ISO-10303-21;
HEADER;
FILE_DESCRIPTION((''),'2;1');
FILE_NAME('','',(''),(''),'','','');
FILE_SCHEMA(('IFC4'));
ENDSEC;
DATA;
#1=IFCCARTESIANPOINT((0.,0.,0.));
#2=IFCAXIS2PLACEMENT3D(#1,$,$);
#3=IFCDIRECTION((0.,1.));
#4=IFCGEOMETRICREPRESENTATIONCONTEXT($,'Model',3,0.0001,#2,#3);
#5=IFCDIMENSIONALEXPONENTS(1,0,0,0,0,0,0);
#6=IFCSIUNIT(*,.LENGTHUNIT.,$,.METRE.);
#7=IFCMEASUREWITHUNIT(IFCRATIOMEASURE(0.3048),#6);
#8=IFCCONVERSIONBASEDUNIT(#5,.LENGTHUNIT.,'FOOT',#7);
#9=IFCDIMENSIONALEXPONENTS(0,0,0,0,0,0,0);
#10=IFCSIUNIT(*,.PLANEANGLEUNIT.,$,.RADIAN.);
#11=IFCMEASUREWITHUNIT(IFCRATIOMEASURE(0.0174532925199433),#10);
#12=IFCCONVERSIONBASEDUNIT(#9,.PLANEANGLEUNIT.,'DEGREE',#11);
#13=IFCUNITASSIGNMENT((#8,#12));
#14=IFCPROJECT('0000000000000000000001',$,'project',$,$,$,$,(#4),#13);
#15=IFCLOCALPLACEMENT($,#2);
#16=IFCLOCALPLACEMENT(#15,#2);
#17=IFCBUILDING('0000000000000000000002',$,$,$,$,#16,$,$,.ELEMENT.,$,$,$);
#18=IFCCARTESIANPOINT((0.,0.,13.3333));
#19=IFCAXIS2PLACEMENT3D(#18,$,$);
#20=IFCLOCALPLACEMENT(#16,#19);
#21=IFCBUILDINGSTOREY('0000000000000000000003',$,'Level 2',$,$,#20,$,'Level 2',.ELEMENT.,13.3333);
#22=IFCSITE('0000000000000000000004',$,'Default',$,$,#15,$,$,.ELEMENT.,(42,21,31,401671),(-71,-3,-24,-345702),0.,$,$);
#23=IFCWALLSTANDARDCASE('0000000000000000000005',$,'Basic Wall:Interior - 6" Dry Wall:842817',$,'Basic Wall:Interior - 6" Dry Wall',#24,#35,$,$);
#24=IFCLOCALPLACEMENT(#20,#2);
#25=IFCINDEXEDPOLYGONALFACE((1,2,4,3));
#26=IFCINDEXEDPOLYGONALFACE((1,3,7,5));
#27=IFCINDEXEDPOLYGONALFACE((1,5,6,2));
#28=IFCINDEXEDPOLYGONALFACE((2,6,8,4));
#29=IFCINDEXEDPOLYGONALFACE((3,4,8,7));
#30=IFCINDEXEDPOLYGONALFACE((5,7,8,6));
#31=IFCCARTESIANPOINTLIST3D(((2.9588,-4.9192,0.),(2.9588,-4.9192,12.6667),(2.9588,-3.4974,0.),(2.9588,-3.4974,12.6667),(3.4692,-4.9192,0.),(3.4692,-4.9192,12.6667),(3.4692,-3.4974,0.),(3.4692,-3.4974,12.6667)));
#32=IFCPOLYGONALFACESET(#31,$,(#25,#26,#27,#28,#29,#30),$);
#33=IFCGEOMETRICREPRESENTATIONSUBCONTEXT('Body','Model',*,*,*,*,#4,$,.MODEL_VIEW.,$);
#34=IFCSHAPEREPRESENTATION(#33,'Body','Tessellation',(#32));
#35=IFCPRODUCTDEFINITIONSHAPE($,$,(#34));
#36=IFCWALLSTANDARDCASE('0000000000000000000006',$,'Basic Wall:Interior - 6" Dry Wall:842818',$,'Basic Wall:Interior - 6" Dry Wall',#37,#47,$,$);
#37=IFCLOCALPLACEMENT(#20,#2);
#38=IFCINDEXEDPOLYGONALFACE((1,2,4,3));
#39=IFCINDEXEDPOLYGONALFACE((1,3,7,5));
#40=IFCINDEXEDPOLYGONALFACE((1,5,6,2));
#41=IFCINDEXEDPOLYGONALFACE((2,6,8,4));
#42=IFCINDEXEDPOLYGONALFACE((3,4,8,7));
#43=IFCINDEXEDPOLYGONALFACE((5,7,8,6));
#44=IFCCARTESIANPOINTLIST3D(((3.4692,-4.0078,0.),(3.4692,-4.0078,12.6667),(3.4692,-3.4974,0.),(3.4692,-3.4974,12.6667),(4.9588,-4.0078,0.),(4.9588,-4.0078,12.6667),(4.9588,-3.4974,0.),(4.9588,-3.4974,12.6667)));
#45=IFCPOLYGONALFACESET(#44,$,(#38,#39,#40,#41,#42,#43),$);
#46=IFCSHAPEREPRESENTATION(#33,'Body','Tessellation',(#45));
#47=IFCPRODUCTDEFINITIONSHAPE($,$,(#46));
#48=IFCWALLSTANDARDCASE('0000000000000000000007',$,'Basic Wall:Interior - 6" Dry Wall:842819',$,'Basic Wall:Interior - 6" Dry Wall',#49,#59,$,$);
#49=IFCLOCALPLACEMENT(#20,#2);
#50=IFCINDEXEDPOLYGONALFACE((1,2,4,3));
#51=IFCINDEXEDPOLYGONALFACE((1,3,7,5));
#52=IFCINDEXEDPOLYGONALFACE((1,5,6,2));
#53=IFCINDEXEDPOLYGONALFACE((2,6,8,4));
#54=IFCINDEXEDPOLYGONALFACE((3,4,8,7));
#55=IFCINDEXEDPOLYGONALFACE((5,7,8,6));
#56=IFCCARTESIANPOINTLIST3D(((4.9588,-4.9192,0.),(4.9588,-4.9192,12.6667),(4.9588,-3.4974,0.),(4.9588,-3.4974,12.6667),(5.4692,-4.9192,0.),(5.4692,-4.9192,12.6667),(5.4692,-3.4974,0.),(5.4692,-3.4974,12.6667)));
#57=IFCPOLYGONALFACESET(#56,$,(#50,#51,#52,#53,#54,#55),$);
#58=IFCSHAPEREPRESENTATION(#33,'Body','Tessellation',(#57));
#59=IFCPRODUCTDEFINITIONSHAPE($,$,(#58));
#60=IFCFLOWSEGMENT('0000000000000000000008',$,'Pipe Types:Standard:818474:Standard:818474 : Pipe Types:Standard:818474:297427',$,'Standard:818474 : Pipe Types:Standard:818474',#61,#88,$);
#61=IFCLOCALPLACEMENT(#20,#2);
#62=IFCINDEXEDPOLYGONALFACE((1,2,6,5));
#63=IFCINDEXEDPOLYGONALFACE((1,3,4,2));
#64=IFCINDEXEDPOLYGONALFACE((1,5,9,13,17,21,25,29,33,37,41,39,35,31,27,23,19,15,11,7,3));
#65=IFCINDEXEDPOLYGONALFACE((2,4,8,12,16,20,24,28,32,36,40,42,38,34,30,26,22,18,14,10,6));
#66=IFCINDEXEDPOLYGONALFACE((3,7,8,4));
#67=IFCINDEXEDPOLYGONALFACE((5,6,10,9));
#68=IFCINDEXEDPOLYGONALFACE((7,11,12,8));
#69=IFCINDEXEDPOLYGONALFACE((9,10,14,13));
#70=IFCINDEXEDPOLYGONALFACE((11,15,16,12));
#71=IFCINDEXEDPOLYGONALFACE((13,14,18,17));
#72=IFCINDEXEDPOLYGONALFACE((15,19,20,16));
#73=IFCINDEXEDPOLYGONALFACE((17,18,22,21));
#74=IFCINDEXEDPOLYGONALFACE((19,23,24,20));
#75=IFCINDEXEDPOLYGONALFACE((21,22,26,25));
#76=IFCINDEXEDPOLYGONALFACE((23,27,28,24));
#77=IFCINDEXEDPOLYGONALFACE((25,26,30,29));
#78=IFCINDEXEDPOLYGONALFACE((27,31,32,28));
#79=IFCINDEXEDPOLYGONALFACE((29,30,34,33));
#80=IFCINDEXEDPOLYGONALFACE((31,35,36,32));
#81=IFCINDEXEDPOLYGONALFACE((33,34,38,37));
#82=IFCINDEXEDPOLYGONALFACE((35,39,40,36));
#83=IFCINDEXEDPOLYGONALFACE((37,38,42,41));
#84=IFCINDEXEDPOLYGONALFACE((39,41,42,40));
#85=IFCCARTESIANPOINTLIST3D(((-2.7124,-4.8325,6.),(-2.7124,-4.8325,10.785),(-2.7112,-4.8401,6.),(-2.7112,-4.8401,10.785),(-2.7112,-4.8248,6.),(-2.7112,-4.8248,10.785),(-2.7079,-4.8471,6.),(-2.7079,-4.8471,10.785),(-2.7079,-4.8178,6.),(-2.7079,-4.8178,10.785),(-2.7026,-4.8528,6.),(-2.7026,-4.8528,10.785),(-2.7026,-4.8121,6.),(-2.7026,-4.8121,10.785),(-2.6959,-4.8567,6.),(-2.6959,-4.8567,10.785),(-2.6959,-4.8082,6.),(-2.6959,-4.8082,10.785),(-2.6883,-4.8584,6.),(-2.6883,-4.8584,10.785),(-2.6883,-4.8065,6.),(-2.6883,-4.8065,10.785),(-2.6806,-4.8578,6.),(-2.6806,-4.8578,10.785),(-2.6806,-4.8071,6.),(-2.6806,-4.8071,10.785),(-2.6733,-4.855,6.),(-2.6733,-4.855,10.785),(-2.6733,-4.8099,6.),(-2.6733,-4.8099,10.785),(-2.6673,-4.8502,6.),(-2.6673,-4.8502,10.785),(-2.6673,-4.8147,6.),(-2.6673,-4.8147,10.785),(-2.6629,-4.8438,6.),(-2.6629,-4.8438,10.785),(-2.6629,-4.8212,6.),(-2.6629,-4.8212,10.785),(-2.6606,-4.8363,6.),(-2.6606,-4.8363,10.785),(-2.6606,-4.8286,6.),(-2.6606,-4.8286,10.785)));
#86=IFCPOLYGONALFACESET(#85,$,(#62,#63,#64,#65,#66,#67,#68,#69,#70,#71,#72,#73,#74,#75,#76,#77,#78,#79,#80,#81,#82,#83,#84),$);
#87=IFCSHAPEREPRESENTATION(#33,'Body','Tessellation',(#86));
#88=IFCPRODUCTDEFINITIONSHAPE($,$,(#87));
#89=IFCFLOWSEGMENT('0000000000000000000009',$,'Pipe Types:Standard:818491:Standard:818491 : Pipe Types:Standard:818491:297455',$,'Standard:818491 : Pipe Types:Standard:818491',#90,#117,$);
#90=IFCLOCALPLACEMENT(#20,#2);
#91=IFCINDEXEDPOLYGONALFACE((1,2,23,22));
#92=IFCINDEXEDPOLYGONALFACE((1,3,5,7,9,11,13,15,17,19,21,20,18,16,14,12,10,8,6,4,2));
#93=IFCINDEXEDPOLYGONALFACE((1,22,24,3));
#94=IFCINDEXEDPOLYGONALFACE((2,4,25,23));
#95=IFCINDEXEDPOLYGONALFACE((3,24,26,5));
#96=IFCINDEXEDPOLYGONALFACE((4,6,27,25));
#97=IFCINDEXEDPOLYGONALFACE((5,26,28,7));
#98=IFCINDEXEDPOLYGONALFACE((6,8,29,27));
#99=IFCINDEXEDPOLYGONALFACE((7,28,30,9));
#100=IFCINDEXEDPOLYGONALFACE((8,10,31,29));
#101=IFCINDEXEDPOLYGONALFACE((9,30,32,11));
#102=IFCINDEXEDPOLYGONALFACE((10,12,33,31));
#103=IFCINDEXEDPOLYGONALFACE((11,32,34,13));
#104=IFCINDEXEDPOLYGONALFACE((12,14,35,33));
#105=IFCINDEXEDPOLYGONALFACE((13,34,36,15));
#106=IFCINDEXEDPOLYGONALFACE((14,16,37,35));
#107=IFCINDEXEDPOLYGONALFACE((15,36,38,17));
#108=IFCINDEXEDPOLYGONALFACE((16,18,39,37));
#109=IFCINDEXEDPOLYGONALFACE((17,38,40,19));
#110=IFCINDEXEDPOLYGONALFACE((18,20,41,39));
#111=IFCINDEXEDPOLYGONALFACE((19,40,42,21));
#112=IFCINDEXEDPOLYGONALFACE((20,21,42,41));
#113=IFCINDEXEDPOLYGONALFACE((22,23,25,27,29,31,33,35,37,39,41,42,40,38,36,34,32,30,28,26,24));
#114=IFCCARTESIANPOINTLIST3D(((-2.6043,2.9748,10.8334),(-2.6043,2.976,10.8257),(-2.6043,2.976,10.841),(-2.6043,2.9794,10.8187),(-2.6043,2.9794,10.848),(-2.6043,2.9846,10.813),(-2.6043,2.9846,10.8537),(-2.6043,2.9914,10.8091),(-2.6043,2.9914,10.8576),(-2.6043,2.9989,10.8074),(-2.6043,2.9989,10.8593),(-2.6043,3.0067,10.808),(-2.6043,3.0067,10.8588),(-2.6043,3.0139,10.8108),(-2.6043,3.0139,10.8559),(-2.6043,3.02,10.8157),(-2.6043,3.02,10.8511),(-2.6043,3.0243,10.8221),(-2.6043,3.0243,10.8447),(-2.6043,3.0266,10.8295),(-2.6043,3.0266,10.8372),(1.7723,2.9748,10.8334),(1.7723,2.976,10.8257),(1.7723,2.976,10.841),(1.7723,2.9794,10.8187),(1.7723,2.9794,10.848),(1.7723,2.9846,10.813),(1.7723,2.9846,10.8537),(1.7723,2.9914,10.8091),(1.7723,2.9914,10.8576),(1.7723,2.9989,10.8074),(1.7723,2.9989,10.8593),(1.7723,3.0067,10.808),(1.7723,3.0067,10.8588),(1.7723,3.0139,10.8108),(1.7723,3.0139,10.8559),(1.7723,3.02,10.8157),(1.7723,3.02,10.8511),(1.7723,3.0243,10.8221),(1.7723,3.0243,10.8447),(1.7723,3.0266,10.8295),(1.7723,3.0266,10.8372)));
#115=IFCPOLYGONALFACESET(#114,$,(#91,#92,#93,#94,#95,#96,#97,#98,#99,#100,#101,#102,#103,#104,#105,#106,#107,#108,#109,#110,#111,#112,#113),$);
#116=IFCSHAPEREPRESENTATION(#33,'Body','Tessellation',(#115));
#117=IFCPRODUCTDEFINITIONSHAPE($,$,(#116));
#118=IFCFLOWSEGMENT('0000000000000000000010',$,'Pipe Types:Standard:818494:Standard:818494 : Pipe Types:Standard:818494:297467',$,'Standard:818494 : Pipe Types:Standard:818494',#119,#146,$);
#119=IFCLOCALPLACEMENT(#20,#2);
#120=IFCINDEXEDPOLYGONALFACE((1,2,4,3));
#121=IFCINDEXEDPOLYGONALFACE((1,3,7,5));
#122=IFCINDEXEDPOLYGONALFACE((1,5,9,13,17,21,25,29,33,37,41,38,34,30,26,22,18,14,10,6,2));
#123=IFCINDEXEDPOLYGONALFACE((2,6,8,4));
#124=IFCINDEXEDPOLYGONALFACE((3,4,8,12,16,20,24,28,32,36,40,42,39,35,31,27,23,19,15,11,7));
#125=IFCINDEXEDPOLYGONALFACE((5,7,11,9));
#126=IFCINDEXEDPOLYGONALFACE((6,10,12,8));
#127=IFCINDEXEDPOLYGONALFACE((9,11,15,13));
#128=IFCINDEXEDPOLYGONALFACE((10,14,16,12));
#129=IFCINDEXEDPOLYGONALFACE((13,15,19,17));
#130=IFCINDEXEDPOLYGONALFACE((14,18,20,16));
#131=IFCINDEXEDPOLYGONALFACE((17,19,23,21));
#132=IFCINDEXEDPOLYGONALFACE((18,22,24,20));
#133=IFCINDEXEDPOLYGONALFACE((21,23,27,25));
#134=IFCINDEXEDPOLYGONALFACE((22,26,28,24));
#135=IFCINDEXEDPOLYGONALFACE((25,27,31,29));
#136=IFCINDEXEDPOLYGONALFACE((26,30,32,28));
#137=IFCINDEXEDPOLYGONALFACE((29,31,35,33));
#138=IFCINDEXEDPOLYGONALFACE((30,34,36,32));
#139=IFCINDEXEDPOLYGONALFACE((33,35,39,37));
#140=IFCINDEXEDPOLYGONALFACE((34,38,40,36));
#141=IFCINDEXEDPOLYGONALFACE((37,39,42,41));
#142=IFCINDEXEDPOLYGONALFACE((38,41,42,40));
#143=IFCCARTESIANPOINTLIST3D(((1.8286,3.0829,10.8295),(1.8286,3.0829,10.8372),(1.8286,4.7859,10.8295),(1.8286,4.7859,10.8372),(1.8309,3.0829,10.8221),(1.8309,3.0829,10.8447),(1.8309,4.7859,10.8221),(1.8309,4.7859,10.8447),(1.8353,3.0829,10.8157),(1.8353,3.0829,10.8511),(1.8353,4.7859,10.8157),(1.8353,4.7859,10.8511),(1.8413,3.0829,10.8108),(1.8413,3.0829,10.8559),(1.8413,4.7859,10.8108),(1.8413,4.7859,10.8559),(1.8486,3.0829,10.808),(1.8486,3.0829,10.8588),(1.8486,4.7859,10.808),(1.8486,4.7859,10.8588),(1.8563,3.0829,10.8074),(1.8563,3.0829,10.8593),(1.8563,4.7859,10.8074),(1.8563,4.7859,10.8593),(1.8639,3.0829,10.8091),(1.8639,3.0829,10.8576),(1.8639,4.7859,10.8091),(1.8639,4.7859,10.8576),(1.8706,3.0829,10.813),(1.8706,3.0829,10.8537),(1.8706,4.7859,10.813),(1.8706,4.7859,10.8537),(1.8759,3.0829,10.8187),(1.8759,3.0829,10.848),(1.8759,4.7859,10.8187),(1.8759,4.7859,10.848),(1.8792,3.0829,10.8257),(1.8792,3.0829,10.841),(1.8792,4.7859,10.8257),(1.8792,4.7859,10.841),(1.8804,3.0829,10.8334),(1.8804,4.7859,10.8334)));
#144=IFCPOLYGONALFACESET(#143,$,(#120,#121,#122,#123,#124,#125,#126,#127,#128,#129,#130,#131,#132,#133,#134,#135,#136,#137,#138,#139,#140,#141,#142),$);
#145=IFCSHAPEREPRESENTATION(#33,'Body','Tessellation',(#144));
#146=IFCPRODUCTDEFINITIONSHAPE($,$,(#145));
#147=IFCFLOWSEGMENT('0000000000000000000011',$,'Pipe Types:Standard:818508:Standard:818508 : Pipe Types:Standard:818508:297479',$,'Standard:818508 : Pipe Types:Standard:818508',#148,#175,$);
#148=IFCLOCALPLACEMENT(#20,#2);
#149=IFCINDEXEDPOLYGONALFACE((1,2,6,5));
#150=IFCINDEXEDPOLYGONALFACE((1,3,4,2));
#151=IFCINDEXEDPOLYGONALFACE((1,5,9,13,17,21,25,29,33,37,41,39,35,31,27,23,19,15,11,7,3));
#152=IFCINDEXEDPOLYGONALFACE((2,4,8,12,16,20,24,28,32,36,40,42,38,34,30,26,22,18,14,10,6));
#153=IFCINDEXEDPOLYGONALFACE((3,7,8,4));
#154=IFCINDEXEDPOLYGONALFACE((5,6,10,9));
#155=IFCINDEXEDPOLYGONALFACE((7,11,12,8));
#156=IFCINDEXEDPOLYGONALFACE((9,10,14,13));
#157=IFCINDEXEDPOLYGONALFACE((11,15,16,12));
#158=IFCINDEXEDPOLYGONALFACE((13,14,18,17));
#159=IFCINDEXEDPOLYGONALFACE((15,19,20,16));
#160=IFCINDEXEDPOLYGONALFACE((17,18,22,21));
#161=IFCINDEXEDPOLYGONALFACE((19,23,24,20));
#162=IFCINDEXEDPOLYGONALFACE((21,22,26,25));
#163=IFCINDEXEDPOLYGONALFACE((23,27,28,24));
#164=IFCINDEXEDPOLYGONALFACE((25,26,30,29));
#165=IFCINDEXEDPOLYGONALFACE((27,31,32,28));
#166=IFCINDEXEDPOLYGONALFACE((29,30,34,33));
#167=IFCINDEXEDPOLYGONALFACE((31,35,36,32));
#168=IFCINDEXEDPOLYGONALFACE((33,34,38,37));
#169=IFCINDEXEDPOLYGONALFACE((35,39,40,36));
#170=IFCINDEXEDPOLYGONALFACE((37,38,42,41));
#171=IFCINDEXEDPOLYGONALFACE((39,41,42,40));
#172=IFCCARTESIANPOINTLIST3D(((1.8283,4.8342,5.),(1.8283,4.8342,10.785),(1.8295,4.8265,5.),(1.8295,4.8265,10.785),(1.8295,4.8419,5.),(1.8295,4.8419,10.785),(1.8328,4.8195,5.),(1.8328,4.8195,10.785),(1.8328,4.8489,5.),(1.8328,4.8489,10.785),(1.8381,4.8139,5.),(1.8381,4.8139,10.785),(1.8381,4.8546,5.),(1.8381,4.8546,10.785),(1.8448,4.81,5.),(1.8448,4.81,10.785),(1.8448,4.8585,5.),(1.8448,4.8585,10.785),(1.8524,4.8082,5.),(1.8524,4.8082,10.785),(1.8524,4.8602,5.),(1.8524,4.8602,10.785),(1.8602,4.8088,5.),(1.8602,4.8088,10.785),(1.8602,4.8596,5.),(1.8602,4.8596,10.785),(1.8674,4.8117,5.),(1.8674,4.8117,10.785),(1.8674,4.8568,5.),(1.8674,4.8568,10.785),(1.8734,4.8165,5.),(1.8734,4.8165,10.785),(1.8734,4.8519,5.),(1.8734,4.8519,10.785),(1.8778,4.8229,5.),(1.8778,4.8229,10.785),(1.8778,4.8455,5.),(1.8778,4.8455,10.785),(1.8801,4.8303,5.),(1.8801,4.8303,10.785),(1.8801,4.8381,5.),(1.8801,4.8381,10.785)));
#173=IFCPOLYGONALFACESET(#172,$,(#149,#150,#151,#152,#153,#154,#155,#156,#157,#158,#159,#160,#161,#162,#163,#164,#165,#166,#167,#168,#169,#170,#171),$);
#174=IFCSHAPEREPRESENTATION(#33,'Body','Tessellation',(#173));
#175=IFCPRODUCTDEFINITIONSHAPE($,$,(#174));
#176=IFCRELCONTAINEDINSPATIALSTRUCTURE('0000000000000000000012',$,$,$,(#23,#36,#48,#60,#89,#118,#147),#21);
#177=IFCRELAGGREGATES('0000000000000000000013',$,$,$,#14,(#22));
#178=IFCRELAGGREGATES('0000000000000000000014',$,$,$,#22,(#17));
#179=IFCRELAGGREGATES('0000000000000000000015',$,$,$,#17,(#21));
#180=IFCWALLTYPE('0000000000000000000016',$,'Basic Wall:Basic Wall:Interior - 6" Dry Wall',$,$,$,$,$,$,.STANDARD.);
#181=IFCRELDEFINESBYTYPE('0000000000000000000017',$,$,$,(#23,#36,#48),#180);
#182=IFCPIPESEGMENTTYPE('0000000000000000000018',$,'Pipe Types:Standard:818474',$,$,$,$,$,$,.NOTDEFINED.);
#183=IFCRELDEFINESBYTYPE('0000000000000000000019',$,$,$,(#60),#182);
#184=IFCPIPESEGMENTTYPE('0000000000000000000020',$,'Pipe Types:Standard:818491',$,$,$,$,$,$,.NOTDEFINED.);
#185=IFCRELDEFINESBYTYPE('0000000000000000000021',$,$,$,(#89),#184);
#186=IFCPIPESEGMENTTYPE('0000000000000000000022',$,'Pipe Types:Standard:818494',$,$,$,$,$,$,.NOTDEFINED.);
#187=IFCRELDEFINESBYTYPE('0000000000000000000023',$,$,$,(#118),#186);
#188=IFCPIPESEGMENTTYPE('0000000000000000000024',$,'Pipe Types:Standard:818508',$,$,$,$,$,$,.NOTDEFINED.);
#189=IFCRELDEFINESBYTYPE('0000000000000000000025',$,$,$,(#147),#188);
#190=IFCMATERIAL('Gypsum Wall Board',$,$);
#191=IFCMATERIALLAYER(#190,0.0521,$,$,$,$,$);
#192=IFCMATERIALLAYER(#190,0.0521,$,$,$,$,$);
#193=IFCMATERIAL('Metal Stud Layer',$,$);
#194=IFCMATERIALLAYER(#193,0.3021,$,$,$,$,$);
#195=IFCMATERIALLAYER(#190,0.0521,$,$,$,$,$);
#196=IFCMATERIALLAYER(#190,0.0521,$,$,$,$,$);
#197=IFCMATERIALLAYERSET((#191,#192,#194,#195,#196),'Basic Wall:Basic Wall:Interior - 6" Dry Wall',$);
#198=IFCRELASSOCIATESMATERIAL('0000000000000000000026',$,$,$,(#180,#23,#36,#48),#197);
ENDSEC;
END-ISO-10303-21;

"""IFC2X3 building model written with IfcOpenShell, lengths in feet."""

from ifc_helpers import new_model, entity, si_unit, converted_unit, direction, frame, frame_2d, origin, origin_2d_with_axis, place, context, subcontext, project, spatial, rectangle, circle, extrude, source, transform, mapped, material, layer, layer_set, layer_usage, type_object, type_shapes, element, save


model = new_model("IFC2X3")

# Units and contexts
model_context = context("Model", 3, precision=0.0001, world=origin(), true_north=direction((0.0, 1.0)))
body_context = subcontext(model_context, "Body", "Model", "MODEL_VIEW")
ifc_project = project(units=[converted_unit("LENGTHUNIT", "FOOT", entity("IfcRatioMeasure", 0.3048), si_unit("LENGTHUNIT", "METRE"), dimensions=[1, 0, 0, 0, 0, 0, 0]), converted_unit("PLANEANGLEUNIT", "DEGREE", entity("IfcRatioMeasure", 0.0174532925199433), si_unit("PLANEANGLEUNIT", "RADIAN"), dimensions=[0, 0, 0, 0, 0, 0, 0])], contexts=[model_context])

# Site, building, storey
site_placement = place(None, origin())
site = spatial("IfcSite", under=ifc_project, at=site_placement, Name="Default", CompositionType="ELEMENT", RefLatitude=(42, 21, 31, 401671), RefLongitude=(-71, -3, -24, -345702), RefElevation=0.0)
building_placement = place(site_placement, origin())
building = spatial("IfcBuilding", under=site, at=building_placement, CompositionType="ELEMENT")
storey_placement = place(building_placement, frame((0.0, 0.0, 13.3333)))
storey = spatial("IfcBuildingStorey", under=building, at=storey_placement, Name="Level 2", LongName="Level 2", CompositionType="ELEMENT", Elevation=13.3333)

# Walls
ifc_material_1 = material(Name="Gypsum Wall Board")
ifc_layer_1 = layer(ifc_material_1, 0.0521)
ifc_layer_2 = layer(ifc_material_1, 0.0521)
ifc_material_2 = material(Name="Metal Stud Layer")
ifc_layer_3 = layer(ifc_material_2, 0.3021)
ifc_layer_4 = layer(ifc_material_1, 0.0521)
ifc_layer_5 = layer(ifc_material_1, 0.0521)
ifc_layer_set = layer_set([ifc_layer_1, ifc_layer_2, ifc_layer_3, ifc_layer_4, ifc_layer_5], Name="Basic Wall:Basic Wall:Interior - 6\" Dry Wall")
ifc_layer_usage_1 = layer_usage(ifc_layer_set, "AXIS2", "NEGATIVE", 0.2552)
wall_type = type_object("IfcWallType", Name="Basic Wall:Basic Wall:Interior - 6\" Dry Wall", PredefinedType="STANDARD", material=ifc_layer_set)
wall_1_placement = place(building_placement, frame((3.214, -4.9192, 13.3333), z_axis=(0.0, 0.0, 1.0), x_axis=(0.0, 1.0, 0.0)))
element("IfcWallStandardCase", 1, at=wall_1_placement, inside=storey, type_object=wall_type, material=ifc_layer_usage_1, Name="Basic Wall:Interior - 6\" Dry Wall:842817", ObjectType="Basic Wall:Interior - 6\" Dry Wall", context=body_context, shape_type="SweptSolid", body=[
    extrude(rectangle(XDim=1.4219, YDim=0.5104, at=frame_2d((0.7109, 0.0), x_axis=(-1.0, 0.0))), origin(), (0.0, 0.0, 1.0), 12.6667),
])
ifc_layer_usage_2 = layer_usage(ifc_layer_set, "AXIS2", "NEGATIVE", 0.2552)
wall_2_placement = place(building_placement, frame((3.4692, -3.7526, 13.3333)))
element("IfcWallStandardCase", 2, at=wall_2_placement, inside=storey, type_object=wall_type, material=ifc_layer_usage_2, Name="Basic Wall:Interior - 6\" Dry Wall:842818", ObjectType="Basic Wall:Interior - 6\" Dry Wall", context=body_context, shape_type="SweptSolid", body=[
    extrude(rectangle(XDim=1.4896, YDim=0.5104, at=frame_2d((0.7448, 0.0), x_axis=(-1.0, 0.0))), origin(), (0.0, 0.0, 1.0), 12.6667),
])
ifc_layer_usage_3 = layer_usage(ifc_layer_set, "AXIS2", "NEGATIVE", 0.2552)
wall_3_placement = place(building_placement, frame((5.214, -3.4974, 13.3333), z_axis=(0.0, 0.0, 1.0), x_axis=(0.0, -1.0, 0.0)))
element("IfcWallStandardCase", 3, at=wall_3_placement, inside=storey, type_object=wall_type, material=ifc_layer_usage_3, Name="Basic Wall:Interior - 6\" Dry Wall:842819", ObjectType="Basic Wall:Interior - 6\" Dry Wall", context=body_context, shape_type="SweptSolid", body=[
    extrude(rectangle(XDim=1.4219, YDim=0.5104, at=frame_2d((0.7109, 0.0), x_axis=(-1.0, 0.0))), origin(), (0.0, 0.0, 1.0), 12.6667),
])

# Flow segments
pipe_segment_type_1 = type_object("IfcPipeSegmentType", Name="Pipe Types:Standard:818474", PredefinedType="NOTDEFINED")
shared_shape_1 = source(origin(), body_context, "Body", "SweptSolid", [
    extrude(circle(Radius=0.026, at=origin_2d_with_axis()), frame((-2.6864, -4.8325, 19.3333), z_axis=(0.0, 0.0, 1.0), x_axis=(-1.0, 0.0, 0.0)), (0.0, 0.0, 1.0), 4.785),
])
type_shapes(pipe_segment_type_1, [shared_shape_1])
flow_segment_1_placement = place(building_placement, origin())
element("IfcFlowSegment", 4, at=flow_segment_1_placement, inside=storey, type_object=pipe_segment_type_1, Name="Pipe Types:Standard:818474:Standard:818474 : Pipe Types:Standard:818474:297427", ObjectType="Standard:818474 : Pipe Types:Standard:818474", context=body_context, shape_type="MappedRepresentation", body=[
    mapped(shared_shape_1, transform((0.0, 0.0, 0.0), scale=1.0)),
])
pipe_segment_type_2 = type_object("IfcPipeSegmentType", Name="Pipe Types:Standard:818491", PredefinedType="NOTDEFINED")
shared_shape_2 = source(origin(), body_context, "Body", "SweptSolid", [
    extrude(circle(Radius=0.026, at=origin_2d_with_axis()), frame((-2.6043, 3.0009, 24.1667), z_axis=(1.0, 0.0, 0.0), x_axis=(0.0, -1.0, 0.0)), (0.0, 0.0, 1.0), 4.3767),
])
type_shapes(pipe_segment_type_2, [shared_shape_2])
flow_segment_2_placement = place(building_placement, origin())
element("IfcFlowSegment", 5, at=flow_segment_2_placement, inside=storey, type_object=pipe_segment_type_2, Name="Pipe Types:Standard:818491:Standard:818491 : Pipe Types:Standard:818491:297455", ObjectType="Standard:818491 : Pipe Types:Standard:818491", context=body_context, shape_type="MappedRepresentation", body=[
    mapped(shared_shape_2, transform((0.0, 0.0, 0.0), scale=1.0)),
])
pipe_segment_type_3 = type_object("IfcPipeSegmentType", Name="Pipe Types:Standard:818494", PredefinedType="NOTDEFINED")
shared_shape_3 = source(origin(), body_context, "Body", "SweptSolid", [
    extrude(circle(Radius=0.026, at=origin_2d_with_axis()), frame((1.8544, 3.0829, 24.1667), z_axis=(0.0, 1.0, 0.0), x_axis=(1.0, 0.0, 0.0)), (0.0, 0.0, 1.0), 1.703),
])
type_shapes(pipe_segment_type_3, [shared_shape_3])
flow_segment_3_placement = place(building_placement, origin())
element("IfcFlowSegment", 6, at=flow_segment_3_placement, inside=storey, type_object=pipe_segment_type_3, Name="Pipe Types:Standard:818494:Standard:818494 : Pipe Types:Standard:818494:297467", ObjectType="Standard:818494 : Pipe Types:Standard:818494", context=body_context, shape_type="MappedRepresentation", body=[
    mapped(shared_shape_3, transform((0.0, 0.0, 0.0), scale=1.0)),
])
pipe_segment_type_4 = type_object("IfcPipeSegmentType", Name="Pipe Types:Standard:818508", PredefinedType="NOTDEFINED")
shared_shape_4 = source(origin(), body_context, "Body", "SweptSolid", [
    extrude(circle(Radius=0.026, at=origin_2d_with_axis()), frame((1.8544, 4.8342, 18.3333), z_axis=(0.0, 0.0, 1.0), x_axis=(-1.0, 0.0, 0.0)), (0.0, 0.0, 1.0), 5.785),
])
type_shapes(pipe_segment_type_4, [shared_shape_4])
flow_segment_4_placement = place(building_placement, origin())
element("IfcFlowSegment", 7, at=flow_segment_4_placement, inside=storey, type_object=pipe_segment_type_4, Name="Pipe Types:Standard:818508:Standard:818508 : Pipe Types:Standard:818508:297479", ObjectType="Standard:818508 : Pipe Types:Standard:818508", context=body_context, shape_type="MappedRepresentation", body=[
    mapped(shared_shape_4, transform((0.0, 0.0, 0.0), scale=1.0)),
])

save(model, "model.ifc")
